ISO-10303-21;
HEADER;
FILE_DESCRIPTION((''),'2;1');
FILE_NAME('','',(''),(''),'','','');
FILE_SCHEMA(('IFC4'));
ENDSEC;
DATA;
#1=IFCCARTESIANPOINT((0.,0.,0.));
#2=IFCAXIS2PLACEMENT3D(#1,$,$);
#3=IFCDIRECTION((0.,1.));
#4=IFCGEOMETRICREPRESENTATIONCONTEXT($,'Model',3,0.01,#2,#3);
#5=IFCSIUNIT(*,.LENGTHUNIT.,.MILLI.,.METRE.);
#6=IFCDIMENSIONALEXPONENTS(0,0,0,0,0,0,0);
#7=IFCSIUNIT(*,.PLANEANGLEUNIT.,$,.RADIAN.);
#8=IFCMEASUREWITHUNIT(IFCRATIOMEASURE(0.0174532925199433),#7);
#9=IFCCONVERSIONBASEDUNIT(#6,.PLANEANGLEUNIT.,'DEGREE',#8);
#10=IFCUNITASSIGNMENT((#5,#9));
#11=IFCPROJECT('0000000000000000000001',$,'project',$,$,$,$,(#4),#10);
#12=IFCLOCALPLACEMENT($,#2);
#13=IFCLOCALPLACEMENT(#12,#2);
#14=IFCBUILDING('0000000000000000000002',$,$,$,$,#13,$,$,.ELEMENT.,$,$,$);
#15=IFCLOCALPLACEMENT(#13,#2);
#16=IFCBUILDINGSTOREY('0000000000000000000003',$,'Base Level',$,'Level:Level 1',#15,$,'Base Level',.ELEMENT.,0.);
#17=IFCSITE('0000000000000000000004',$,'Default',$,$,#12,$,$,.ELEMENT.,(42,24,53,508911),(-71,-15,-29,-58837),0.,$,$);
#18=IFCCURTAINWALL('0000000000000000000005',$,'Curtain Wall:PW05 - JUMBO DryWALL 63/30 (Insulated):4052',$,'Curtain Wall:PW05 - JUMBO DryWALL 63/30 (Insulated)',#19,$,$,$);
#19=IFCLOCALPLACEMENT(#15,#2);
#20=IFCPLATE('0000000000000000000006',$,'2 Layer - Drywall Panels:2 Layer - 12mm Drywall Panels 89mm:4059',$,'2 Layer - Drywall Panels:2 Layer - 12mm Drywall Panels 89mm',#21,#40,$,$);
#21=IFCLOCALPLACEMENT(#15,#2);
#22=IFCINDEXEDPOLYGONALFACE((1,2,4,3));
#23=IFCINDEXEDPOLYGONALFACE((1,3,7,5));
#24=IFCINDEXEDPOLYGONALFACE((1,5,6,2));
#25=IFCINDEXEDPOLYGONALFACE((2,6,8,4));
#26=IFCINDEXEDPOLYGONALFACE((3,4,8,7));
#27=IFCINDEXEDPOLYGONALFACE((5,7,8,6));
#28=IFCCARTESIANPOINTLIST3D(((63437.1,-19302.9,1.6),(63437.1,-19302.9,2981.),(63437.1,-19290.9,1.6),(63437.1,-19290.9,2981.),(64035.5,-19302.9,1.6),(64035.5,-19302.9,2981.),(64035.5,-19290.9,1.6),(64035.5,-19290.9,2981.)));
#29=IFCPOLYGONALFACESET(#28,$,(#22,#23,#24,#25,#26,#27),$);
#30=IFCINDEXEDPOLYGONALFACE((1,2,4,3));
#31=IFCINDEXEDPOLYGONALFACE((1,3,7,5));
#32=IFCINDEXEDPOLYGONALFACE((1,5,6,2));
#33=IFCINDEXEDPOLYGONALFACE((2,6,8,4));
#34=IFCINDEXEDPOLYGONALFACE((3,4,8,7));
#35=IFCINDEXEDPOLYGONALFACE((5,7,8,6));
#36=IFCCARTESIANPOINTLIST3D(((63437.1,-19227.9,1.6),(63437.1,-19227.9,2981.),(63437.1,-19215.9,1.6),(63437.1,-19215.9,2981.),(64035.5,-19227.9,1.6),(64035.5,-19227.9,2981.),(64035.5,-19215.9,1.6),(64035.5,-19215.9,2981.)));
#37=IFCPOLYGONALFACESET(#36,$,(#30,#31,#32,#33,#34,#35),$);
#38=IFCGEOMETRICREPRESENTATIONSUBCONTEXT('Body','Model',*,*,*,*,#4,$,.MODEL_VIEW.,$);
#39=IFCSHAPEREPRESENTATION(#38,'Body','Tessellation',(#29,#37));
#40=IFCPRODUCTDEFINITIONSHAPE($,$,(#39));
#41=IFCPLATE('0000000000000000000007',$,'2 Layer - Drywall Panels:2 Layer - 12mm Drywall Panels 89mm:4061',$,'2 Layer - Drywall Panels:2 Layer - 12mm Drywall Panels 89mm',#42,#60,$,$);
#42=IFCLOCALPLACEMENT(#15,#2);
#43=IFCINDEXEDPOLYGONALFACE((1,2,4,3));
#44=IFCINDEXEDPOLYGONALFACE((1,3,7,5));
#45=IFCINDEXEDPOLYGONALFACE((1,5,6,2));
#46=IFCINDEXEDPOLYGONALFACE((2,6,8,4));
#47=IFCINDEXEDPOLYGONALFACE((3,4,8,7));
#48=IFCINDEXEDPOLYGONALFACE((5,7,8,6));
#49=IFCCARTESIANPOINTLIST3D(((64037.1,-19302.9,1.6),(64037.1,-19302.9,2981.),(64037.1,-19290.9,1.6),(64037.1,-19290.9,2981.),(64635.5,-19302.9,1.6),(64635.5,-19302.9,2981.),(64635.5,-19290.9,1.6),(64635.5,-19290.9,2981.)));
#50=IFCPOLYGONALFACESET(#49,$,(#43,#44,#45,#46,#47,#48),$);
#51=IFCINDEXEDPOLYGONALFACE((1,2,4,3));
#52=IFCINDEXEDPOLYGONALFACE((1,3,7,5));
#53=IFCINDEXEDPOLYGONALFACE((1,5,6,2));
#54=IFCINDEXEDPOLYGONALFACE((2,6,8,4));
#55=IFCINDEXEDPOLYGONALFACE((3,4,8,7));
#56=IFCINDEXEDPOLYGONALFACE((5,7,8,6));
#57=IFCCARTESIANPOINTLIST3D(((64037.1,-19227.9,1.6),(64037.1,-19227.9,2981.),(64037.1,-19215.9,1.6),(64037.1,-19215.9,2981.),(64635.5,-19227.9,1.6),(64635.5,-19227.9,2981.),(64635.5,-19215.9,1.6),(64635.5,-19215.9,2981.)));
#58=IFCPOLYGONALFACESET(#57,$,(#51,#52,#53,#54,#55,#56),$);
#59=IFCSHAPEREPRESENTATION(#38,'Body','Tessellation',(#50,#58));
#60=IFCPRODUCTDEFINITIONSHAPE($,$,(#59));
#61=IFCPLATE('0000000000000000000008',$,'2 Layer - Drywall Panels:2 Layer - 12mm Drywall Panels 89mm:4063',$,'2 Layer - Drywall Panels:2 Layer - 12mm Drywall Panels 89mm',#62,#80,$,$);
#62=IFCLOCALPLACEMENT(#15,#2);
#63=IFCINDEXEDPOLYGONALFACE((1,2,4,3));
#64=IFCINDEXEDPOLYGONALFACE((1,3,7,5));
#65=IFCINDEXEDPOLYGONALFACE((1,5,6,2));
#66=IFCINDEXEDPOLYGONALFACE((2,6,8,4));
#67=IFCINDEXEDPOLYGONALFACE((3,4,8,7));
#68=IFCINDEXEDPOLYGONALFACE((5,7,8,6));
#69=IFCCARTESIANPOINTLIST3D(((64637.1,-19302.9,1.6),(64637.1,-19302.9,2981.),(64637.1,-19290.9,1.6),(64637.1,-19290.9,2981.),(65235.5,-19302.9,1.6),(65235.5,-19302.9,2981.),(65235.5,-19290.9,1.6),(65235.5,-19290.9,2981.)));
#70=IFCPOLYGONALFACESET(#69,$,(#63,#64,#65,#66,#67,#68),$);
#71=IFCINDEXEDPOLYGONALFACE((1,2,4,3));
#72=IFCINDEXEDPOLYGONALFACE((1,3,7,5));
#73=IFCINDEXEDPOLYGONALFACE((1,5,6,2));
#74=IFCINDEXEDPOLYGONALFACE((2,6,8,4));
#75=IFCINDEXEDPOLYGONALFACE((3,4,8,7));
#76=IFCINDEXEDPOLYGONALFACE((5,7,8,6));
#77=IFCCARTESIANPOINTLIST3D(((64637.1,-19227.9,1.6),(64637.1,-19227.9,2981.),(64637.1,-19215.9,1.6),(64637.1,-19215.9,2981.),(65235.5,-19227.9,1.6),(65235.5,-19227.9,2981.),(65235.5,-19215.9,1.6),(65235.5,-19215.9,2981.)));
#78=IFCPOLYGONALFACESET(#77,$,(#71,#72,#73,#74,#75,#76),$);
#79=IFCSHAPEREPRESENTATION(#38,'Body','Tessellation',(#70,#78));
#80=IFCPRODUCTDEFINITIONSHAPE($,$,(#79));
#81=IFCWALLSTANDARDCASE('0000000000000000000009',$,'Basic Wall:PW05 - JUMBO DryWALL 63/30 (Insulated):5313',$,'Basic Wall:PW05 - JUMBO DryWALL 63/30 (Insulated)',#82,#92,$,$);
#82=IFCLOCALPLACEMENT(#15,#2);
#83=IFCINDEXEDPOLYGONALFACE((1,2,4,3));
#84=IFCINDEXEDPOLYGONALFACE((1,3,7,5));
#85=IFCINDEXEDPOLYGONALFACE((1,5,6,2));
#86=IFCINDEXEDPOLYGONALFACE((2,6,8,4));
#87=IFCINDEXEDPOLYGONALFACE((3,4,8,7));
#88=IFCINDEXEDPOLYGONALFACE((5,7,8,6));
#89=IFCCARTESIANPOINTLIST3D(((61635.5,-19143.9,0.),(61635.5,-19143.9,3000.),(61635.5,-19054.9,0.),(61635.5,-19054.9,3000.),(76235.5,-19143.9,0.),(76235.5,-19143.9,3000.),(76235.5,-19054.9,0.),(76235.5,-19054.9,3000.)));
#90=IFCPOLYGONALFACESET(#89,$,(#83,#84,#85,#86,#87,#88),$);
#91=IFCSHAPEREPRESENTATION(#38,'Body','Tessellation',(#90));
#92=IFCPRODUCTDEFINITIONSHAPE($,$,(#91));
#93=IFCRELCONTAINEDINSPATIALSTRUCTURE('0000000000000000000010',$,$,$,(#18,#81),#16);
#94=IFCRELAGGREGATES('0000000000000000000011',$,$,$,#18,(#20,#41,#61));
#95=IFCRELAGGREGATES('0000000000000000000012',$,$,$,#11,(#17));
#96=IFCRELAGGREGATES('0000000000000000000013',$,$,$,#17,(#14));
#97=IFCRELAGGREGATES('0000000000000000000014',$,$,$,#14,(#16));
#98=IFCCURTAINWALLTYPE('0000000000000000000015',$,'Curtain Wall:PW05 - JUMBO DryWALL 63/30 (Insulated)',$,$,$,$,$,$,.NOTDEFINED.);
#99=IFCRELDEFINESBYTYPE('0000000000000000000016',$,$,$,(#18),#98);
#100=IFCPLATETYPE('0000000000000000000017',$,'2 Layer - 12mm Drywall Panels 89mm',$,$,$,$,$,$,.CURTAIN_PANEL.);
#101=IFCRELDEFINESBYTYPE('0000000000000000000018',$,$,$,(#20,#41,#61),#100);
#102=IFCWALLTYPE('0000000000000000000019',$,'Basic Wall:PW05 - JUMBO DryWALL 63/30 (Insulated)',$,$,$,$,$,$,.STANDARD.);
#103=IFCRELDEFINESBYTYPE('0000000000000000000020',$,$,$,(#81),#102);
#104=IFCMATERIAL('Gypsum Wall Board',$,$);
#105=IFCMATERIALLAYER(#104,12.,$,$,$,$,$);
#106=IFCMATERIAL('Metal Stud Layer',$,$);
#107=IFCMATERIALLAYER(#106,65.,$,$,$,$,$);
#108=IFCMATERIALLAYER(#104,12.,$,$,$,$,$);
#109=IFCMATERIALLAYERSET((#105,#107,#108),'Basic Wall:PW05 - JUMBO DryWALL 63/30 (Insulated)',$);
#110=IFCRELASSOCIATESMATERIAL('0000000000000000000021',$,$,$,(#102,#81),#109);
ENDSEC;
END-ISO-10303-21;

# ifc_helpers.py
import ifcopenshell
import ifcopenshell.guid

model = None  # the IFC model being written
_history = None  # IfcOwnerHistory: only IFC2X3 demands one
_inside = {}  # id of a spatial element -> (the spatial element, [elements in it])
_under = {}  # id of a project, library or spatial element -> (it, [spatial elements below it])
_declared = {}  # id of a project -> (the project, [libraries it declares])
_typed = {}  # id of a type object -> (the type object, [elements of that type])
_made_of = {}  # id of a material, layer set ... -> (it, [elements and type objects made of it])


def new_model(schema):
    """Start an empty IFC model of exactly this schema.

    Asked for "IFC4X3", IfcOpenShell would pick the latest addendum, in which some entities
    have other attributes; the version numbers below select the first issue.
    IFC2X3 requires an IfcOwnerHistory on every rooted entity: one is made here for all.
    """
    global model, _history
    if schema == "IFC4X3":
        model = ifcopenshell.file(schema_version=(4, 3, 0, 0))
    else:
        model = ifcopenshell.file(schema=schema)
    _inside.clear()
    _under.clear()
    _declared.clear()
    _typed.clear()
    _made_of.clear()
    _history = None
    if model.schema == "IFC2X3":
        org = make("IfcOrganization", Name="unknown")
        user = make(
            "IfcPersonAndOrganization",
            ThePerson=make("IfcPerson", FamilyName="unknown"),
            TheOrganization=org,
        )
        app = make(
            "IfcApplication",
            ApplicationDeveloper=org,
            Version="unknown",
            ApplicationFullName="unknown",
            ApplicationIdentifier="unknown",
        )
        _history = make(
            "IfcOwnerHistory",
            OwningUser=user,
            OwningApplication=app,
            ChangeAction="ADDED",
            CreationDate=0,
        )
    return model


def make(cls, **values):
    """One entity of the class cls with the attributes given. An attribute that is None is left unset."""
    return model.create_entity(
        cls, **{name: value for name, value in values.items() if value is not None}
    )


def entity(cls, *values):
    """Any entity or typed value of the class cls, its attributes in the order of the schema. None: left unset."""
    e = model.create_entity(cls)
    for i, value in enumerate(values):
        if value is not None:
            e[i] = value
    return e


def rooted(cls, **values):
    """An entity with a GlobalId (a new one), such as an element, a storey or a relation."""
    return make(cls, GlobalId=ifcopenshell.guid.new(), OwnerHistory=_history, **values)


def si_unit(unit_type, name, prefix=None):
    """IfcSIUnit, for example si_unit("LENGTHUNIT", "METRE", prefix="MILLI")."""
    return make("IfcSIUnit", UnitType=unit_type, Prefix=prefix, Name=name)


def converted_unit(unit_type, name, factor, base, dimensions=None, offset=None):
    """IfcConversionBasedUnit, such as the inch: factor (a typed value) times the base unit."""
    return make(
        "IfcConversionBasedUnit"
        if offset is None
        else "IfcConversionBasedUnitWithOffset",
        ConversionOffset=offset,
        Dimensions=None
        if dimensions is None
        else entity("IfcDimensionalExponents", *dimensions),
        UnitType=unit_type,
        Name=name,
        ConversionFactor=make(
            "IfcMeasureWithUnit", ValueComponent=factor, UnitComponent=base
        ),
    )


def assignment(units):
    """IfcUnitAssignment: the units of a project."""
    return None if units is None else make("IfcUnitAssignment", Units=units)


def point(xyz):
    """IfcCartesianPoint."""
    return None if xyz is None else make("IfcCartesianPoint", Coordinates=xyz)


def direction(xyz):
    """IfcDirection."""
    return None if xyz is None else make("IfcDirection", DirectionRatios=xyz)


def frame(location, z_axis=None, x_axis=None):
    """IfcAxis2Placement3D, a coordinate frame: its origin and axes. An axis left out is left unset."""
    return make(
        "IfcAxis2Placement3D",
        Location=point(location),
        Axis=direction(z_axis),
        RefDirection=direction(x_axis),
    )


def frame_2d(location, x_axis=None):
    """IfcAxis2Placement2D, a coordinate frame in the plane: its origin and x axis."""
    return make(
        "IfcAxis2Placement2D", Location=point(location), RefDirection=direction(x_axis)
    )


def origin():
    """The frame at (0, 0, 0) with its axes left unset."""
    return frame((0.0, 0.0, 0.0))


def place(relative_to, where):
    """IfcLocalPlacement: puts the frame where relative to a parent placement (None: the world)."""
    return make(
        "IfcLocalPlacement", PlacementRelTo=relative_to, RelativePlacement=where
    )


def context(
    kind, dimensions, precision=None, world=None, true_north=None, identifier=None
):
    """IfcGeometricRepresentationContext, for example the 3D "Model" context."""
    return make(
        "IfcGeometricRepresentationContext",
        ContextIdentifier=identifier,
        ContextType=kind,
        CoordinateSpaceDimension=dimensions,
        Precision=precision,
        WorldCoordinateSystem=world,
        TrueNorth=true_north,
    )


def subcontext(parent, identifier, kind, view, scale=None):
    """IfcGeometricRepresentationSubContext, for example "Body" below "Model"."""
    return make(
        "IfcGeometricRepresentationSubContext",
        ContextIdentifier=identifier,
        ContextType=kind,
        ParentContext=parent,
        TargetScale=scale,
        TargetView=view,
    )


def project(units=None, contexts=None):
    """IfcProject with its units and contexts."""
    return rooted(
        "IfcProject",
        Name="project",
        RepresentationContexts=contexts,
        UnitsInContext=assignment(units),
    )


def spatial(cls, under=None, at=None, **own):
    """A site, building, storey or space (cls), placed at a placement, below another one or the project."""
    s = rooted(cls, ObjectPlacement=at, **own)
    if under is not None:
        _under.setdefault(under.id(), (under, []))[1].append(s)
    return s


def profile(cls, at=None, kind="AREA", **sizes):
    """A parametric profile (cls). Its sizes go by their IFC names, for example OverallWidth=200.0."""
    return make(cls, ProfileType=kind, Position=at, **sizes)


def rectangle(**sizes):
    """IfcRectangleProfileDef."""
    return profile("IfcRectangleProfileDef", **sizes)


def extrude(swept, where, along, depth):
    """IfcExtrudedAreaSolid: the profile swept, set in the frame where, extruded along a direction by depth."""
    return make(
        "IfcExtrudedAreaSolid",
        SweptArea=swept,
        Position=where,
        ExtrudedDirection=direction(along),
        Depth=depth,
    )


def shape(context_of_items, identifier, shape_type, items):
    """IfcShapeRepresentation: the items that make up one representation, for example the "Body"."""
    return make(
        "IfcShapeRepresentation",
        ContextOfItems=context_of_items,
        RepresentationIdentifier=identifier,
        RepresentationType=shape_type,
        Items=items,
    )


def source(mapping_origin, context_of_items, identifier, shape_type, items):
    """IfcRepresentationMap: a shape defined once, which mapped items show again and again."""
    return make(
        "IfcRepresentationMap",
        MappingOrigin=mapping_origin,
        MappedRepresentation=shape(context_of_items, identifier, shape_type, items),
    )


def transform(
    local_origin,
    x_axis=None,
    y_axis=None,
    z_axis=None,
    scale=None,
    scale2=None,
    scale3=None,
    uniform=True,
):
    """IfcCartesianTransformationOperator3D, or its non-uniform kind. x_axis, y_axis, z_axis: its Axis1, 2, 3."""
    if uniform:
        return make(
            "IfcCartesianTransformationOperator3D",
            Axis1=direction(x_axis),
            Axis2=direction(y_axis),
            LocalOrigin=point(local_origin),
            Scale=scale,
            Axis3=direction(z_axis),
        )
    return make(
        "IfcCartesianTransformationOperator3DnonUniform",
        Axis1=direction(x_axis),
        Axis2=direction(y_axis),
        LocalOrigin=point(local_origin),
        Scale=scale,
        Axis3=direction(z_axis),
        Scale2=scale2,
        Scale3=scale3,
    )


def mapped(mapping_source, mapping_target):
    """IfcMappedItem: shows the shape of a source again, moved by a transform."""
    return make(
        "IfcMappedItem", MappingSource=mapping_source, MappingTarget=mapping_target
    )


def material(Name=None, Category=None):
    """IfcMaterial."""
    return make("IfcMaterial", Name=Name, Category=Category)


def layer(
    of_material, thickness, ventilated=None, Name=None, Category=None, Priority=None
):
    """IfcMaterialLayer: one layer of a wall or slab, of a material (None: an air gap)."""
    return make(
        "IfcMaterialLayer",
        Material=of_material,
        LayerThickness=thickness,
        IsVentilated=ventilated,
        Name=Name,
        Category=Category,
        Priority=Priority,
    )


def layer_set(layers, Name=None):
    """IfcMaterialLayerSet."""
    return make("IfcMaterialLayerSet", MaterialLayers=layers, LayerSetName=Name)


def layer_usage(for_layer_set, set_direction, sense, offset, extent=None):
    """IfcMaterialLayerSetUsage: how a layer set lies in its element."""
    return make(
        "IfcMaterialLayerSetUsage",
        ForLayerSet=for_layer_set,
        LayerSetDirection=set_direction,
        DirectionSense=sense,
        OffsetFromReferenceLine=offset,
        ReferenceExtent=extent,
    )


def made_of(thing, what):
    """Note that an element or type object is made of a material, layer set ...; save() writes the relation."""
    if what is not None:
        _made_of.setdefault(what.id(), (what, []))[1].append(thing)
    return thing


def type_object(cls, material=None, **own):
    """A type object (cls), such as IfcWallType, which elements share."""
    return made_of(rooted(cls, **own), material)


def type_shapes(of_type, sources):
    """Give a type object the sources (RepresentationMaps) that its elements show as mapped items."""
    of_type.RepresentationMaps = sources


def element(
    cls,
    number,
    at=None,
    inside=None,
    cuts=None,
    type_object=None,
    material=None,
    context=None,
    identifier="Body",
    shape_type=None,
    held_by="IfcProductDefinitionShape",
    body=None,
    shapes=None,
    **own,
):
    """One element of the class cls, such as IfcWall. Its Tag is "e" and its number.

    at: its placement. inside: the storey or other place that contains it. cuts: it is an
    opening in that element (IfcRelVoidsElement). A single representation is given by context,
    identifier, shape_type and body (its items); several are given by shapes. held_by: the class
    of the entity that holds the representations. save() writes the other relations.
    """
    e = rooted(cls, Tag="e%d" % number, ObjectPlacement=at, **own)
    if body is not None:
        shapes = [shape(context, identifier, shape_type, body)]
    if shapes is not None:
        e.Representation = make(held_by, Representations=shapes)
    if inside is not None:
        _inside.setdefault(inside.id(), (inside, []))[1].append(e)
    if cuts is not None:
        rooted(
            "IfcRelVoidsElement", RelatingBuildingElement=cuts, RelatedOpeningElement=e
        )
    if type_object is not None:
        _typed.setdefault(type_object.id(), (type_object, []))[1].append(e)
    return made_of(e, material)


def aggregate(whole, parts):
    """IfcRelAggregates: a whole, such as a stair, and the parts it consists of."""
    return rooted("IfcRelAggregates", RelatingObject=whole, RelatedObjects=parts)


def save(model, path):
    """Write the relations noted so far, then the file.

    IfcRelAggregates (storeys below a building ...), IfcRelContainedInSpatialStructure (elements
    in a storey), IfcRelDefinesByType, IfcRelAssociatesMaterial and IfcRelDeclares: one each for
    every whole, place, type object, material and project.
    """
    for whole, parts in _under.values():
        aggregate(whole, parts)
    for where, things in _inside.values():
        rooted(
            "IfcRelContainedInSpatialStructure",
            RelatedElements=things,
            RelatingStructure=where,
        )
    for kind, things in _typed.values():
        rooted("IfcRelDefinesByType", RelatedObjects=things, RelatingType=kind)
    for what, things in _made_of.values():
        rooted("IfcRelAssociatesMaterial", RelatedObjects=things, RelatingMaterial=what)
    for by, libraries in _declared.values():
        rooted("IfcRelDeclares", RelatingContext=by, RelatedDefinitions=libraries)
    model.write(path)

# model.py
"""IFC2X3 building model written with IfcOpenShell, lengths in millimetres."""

from ifc_helpers import new_model, entity, si_unit, converted_unit, direction, frame, frame_2d, origin, place, context, subcontext, project, spatial, rectangle, extrude, source, transform, mapped, material, layer, layer_set, layer_usage, type_object, type_shapes, element, aggregate, save


model = new_model("IFC2X3")

# Units and contexts
model_context = context("Model", 3, precision=0.01, world=origin(), true_north=direction((0.0, 1.0)))
body_context = subcontext(model_context, "Body", "Model", "MODEL_VIEW")
ifc_project = project(units=[si_unit("LENGTHUNIT", "METRE", prefix="MILLI"), converted_unit("PLANEANGLEUNIT", "DEGREE", entity("IfcRatioMeasure", 0.0174532925199433), si_unit("PLANEANGLEUNIT", "RADIAN"), dimensions=[0, 0, 0, 0, 0, 0, 0])], contexts=[model_context])

# Site, building, storey
site_placement = place(None, origin())
site = spatial("IfcSite", under=ifc_project, at=site_placement, Name="Default", CompositionType="ELEMENT", RefLatitude=(42, 24, 53, 508911), RefLongitude=(-71, -15, -29, -58837), RefElevation=0.0)
building_placement = place(site_placement, origin())
building = spatial("IfcBuilding", under=site, at=building_placement, CompositionType="ELEMENT")
storey_placement = place(building_placement, origin())
storey = spatial("IfcBuildingStorey", under=building, at=storey_placement, Name="Base Level", ObjectType="Level:Level 1", LongName="Base Level", CompositionType="ELEMENT", Elevation=0.0)

# Curtain wall, plates
curtain_wall_type = type_object("IfcCurtainWallType", Name="Curtain Wall:PW05 - JUMBO DryWALL 63/30 (Insulated)", PredefinedType="NOTDEFINED")
curtain_wall_placement = place(building_placement, origin())
curtain_wall = element("IfcCurtainWall", 1, at=curtain_wall_placement, inside=storey, type_object=curtain_wall_type, Name="Curtain Wall:PW05 - JUMBO DryWALL 63/30 (Insulated):4052", ObjectType="Curtain Wall:PW05 - JUMBO DryWALL 63/30 (Insulated)")
plate_type = type_object("IfcPlateType", Name="2 Layer - 12mm Drywall Panels 89mm", PredefinedType="CURTAIN_PANEL")
shared_shape_1 = source(origin(), body_context, "Body", "SweptSolid", [
    extrude(rectangle(XDim=598.4, YDim=12.0, at=frame_2d((0.0, 0.0), x_axis=(1.0, 0.0))), frame((0.0, -37.5, 0.0), z_axis=(0.0, 0.0, 1.0), x_axis=(-1.0, 0.0, 0.0)), (0.0, 0.0, 1.0), 2979.4),
    extrude(rectangle(XDim=12.0, YDim=598.4, at=frame_2d((0.0, 0.0), x_axis=(1.0, 0.0))), frame((0.0, 37.5, 0.0), z_axis=(0.0, 0.0, 1.0), x_axis=(0.0, 1.0, 0.0)), (0.0, 0.0, 1.0), 2979.4),
])
type_shapes(plate_type, [shared_shape_1])
plate_1_placement = place(curtain_wall_placement, frame((63736.3, -19259.4, 1.6)))
plate_1 = element("IfcPlate", 2, at=plate_1_placement, type_object=plate_type, Name="2 Layer - Drywall Panels:2 Layer - 12mm Drywall Panels 89mm:4059", ObjectType="2 Layer - Drywall Panels:2 Layer - 12mm Drywall Panels 89mm", context=body_context, shape_type="MappedRepresentation", body=[
    mapped(shared_shape_1, transform((0.0, 0.0, 0.0), scale=1.0)),
])
plate_2_placement = place(curtain_wall_placement, frame((64336.3, -19259.4, 1.6)))
plate_2 = element("IfcPlate", 3, at=plate_2_placement, type_object=plate_type, Name="2 Layer - Drywall Panels:2 Layer - 12mm Drywall Panels 89mm:4061", ObjectType="2 Layer - Drywall Panels:2 Layer - 12mm Drywall Panels 89mm", context=body_context, shape_type="MappedRepresentation", body=[
    mapped(shared_shape_1, transform((0.0, 0.0, 0.0), scale=1.0)),
])
plate_3_placement = place(curtain_wall_placement, frame((64936.3, -19259.4, 1.6)))
plate_3 = element("IfcPlate", 4, at=plate_3_placement, type_object=plate_type, Name="2 Layer - Drywall Panels:2 Layer - 12mm Drywall Panels 89mm:4063", ObjectType="2 Layer - Drywall Panels:2 Layer - 12mm Drywall Panels 89mm", context=body_context, shape_type="MappedRepresentation", body=[
    mapped(shared_shape_1, transform((0.0, 0.0, 0.0), scale=1.0)),
])
aggregate(curtain_wall, [plate_1, plate_2, plate_3])

# Wall
ifc_material_1 = material(Name="Gypsum Wall Board")
ifc_layer_1 = layer(ifc_material_1, 12.0)
ifc_material_2 = material(Name="Metal Stud Layer")
ifc_layer_2 = layer(ifc_material_2, 65.0)
ifc_layer_3 = layer(ifc_material_1, 12.0)
ifc_layer_set = layer_set([ifc_layer_1, ifc_layer_2, ifc_layer_3], Name="Basic Wall:PW05 - JUMBO DryWALL 63/30 (Insulated)")
ifc_layer_usage = layer_usage(ifc_layer_set, "AXIS2", "NEGATIVE", 44.5)
wall_type = type_object("IfcWallType", Name="Basic Wall:PW05 - JUMBO DryWALL 63/30 (Insulated)", PredefinedType="STANDARD", material=ifc_layer_set)
wall_placement = place(building_placement, frame((61635.5, -19099.4, 0.0)))
element("IfcWallStandardCase", 5, at=wall_placement, inside=storey, type_object=wall_type, material=ifc_layer_usage, Name="Basic Wall:PW05 - JUMBO DryWALL 63/30 (Insulated):5313", ObjectType="Basic Wall:PW05 - JUMBO DryWALL 63/30 (Insulated)", context=body_context, shape_type="SweptSolid", body=[
    extrude(rectangle(XDim=14600.0, YDim=89.0, at=frame_2d((7300.0, 0.0), x_axis=(-1.0, 0.0))), origin(), (0.0, 0.0, 1.0), 3000.0),
])

save(model, "model.ifc")
